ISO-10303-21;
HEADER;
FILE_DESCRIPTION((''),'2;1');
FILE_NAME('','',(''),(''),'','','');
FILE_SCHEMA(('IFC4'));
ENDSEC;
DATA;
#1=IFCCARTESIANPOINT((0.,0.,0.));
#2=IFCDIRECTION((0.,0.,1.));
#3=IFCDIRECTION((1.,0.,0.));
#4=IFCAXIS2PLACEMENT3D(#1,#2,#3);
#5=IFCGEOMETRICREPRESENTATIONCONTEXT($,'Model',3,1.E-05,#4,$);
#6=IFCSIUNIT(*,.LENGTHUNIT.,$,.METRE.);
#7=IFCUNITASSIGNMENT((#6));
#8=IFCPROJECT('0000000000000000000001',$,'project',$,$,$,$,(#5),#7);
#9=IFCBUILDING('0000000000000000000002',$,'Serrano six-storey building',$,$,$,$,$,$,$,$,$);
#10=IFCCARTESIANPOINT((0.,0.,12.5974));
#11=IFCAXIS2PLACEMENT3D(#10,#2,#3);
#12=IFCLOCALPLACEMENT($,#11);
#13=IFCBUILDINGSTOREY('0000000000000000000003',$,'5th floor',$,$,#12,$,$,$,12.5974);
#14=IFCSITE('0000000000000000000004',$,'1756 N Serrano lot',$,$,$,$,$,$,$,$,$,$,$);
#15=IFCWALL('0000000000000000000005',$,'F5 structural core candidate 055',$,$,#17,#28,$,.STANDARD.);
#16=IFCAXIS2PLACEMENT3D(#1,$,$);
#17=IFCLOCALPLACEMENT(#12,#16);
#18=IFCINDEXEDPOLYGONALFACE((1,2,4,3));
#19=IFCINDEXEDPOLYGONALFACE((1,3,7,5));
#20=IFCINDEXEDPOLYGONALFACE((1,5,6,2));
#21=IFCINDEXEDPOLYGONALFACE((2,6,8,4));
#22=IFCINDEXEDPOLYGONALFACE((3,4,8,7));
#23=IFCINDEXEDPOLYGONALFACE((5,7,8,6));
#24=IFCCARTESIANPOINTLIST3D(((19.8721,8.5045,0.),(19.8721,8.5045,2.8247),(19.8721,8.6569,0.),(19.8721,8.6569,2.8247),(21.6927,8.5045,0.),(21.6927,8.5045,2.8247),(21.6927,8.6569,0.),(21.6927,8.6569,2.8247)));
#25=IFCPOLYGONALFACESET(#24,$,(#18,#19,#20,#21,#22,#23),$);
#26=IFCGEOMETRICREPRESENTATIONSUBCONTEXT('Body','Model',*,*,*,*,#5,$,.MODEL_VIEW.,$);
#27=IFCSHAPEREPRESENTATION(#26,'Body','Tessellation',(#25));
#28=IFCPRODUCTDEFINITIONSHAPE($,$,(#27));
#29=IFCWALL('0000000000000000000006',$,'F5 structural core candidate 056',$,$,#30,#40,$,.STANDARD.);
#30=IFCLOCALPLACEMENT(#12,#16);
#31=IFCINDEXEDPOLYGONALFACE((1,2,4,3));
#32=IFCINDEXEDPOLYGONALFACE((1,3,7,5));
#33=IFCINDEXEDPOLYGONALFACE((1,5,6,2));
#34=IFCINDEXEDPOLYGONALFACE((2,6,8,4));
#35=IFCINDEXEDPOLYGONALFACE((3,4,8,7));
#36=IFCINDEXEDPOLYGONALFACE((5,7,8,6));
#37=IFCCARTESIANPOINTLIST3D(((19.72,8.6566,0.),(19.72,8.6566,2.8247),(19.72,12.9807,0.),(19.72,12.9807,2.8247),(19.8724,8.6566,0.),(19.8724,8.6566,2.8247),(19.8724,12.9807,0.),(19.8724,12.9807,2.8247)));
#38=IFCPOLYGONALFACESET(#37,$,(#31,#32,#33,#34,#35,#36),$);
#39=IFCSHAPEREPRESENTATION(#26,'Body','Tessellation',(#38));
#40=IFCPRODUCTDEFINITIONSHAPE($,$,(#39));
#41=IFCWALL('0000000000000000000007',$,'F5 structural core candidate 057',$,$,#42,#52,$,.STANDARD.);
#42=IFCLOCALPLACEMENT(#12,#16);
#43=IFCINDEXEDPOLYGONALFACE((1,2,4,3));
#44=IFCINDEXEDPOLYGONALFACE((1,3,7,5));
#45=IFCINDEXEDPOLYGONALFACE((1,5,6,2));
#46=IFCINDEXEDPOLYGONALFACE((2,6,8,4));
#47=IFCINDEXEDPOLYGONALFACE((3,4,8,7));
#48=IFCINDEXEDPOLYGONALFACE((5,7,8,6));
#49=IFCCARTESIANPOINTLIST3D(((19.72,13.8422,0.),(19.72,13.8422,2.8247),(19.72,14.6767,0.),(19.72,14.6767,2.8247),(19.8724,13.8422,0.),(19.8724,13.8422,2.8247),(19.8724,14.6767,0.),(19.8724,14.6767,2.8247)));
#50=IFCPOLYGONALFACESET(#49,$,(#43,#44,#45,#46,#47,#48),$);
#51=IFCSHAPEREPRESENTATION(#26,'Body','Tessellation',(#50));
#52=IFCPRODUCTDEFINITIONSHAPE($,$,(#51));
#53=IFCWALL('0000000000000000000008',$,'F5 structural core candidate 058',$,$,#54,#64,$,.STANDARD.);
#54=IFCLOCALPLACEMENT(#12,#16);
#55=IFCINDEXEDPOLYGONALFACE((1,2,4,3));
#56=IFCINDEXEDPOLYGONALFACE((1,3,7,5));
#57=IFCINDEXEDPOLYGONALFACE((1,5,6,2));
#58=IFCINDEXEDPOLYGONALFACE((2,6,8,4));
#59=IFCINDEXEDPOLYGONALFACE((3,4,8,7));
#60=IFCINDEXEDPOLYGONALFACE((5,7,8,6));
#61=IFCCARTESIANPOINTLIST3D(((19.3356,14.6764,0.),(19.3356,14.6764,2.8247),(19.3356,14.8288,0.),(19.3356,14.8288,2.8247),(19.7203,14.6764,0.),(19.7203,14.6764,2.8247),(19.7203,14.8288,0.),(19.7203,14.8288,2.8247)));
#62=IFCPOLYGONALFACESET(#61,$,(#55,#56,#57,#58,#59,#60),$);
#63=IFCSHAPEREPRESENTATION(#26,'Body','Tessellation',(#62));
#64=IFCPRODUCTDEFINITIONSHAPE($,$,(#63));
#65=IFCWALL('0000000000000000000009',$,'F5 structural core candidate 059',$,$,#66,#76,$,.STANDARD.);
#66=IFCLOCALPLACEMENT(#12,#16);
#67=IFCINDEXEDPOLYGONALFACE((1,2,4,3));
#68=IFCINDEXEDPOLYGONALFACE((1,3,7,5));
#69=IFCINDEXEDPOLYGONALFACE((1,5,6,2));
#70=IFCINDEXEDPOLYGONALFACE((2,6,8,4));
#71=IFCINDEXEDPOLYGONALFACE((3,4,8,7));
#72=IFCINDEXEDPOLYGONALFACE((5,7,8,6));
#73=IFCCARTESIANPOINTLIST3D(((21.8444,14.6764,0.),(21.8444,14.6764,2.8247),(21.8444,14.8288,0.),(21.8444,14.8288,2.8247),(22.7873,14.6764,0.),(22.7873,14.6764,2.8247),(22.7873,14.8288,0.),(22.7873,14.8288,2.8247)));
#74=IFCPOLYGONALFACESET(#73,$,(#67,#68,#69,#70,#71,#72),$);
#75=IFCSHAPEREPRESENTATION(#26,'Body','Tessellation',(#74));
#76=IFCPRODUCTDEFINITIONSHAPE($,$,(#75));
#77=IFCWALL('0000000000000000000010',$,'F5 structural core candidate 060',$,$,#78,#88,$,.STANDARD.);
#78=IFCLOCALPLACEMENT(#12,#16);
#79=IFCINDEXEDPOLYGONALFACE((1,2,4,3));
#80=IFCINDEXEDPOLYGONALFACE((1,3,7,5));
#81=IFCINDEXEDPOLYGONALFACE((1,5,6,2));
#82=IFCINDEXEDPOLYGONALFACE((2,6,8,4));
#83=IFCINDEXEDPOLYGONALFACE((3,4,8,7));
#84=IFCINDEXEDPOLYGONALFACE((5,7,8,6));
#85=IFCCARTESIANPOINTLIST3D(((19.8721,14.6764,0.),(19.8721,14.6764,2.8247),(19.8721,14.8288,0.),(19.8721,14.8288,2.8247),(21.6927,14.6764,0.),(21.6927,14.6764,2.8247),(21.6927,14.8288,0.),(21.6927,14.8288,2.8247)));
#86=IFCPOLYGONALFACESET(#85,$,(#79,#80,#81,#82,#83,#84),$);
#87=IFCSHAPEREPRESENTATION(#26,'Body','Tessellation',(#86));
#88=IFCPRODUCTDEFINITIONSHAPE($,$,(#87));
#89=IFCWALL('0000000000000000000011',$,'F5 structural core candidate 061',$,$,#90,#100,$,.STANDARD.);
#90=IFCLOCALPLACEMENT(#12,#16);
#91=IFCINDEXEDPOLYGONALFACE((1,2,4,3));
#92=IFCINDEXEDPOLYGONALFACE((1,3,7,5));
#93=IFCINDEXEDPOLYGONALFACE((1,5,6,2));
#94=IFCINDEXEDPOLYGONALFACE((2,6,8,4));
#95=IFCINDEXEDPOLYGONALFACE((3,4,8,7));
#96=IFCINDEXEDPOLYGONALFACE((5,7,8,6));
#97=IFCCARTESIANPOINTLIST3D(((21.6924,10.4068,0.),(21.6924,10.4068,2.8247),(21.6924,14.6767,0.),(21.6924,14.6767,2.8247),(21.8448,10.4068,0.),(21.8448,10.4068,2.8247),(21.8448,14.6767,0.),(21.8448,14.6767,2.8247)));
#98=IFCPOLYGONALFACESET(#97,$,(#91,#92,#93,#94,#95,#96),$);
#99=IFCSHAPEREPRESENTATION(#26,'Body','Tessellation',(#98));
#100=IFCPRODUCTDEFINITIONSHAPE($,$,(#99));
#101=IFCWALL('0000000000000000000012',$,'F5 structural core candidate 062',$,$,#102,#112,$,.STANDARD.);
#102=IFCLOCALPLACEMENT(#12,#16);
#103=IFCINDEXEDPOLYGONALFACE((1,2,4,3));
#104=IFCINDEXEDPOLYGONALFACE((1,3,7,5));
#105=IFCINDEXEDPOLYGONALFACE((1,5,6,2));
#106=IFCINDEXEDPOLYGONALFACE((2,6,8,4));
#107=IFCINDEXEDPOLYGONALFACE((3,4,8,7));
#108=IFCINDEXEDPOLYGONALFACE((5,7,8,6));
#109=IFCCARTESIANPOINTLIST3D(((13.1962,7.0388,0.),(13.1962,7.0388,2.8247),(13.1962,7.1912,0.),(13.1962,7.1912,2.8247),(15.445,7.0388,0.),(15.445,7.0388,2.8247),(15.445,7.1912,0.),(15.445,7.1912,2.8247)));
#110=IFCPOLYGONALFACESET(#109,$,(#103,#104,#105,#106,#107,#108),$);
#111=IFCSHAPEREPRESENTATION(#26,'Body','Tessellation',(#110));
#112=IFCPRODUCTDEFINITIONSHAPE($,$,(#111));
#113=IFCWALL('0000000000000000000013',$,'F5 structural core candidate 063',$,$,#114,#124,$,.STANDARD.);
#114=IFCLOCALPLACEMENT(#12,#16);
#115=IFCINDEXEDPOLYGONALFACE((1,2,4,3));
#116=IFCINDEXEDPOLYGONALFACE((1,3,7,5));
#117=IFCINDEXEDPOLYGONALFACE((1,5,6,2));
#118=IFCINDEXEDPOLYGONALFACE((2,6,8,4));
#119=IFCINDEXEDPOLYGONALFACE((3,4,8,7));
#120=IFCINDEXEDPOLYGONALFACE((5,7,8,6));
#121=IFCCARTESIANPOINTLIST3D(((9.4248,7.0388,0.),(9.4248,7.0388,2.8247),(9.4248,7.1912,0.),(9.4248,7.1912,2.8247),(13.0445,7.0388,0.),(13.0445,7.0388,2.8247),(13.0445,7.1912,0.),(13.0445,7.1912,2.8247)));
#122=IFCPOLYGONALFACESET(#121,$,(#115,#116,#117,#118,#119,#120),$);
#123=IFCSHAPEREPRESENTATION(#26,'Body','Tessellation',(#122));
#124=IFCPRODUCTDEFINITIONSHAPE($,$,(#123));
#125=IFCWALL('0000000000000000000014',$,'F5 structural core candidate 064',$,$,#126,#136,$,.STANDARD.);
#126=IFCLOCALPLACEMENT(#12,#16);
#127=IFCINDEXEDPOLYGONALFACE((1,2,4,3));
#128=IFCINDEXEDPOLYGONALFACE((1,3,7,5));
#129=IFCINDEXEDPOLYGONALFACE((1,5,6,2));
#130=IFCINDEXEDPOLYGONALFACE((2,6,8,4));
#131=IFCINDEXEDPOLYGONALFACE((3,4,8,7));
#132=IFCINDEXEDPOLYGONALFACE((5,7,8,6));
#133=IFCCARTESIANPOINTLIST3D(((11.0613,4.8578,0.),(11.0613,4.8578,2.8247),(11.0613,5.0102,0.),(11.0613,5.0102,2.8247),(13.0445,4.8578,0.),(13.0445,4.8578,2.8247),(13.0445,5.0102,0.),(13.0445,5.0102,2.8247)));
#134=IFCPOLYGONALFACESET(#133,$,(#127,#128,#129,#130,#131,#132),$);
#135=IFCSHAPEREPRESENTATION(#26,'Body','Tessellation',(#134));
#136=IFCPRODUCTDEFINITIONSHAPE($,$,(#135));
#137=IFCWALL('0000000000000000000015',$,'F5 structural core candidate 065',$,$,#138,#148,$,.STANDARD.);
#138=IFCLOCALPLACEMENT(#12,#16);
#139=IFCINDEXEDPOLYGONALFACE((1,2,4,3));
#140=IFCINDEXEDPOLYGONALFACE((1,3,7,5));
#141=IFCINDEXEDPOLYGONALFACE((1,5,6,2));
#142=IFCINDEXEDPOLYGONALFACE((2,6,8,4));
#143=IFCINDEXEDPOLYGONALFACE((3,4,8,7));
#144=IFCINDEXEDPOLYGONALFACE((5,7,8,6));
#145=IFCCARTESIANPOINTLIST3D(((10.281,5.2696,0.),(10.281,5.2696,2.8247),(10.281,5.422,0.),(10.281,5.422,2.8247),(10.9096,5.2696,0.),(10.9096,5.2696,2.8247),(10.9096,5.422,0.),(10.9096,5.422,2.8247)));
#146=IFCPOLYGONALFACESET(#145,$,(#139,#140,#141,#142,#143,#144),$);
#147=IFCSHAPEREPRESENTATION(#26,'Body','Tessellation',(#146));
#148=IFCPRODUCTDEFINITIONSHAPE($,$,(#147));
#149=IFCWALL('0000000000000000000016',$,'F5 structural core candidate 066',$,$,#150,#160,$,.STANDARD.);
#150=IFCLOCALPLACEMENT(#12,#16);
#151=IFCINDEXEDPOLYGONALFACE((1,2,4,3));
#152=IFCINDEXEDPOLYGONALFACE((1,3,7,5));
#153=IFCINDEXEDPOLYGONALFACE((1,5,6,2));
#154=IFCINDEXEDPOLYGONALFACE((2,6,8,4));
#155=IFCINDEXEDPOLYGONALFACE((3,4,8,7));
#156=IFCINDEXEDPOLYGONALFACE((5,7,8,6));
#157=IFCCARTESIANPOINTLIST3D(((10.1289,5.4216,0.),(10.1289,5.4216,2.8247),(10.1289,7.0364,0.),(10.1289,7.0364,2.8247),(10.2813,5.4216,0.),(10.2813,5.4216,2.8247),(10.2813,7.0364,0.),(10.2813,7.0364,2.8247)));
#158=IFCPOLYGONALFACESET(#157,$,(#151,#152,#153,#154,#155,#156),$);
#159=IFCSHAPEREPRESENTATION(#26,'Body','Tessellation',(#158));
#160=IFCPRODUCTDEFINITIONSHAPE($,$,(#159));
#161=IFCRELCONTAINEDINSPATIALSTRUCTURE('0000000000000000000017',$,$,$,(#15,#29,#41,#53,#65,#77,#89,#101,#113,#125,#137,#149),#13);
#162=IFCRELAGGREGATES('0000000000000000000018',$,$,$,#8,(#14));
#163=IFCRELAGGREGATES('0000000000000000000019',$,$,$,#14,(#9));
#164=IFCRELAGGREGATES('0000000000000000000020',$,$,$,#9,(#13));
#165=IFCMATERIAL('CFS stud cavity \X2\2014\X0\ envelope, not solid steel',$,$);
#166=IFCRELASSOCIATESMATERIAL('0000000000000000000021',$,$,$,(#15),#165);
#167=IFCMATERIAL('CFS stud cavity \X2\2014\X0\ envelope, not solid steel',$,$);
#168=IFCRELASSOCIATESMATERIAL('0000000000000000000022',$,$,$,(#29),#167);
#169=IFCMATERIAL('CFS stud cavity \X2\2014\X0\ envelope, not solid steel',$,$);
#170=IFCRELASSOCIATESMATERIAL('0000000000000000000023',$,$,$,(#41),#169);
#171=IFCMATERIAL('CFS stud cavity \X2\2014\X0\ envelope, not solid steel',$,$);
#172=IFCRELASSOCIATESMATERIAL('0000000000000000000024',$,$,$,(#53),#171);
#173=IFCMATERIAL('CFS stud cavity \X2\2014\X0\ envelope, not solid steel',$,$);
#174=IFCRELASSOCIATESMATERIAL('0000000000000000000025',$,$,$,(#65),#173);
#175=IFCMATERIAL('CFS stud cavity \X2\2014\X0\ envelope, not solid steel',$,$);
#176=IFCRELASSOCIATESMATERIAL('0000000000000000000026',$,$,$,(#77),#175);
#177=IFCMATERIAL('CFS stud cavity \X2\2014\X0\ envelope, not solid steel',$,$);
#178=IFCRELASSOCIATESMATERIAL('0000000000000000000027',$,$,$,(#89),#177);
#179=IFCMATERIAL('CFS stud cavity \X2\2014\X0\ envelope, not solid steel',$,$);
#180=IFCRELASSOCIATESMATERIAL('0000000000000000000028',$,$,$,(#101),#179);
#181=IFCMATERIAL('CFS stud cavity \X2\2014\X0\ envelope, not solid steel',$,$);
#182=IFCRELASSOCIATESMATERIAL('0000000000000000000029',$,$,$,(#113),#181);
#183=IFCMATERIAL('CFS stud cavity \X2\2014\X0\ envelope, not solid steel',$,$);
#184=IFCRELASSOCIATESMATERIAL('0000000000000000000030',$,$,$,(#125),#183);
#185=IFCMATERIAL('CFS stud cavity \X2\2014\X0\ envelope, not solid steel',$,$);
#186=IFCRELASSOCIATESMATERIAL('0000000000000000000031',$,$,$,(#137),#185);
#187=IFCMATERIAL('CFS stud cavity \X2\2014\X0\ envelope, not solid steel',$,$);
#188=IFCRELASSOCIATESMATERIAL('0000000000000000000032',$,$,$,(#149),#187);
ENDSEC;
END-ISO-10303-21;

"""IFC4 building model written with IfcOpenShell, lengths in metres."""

from ifc_helpers import new_model, si_unit, frame, origin_with_axes, place, context, subcontext, project, spatial, polyline, outline, extrude, material, element, save


model = new_model("IFC4")

# Units and contexts
model_context = context("Model", 3, precision=1e-05, world=origin_with_axes())
body_context = subcontext(model_context, "Body", "Model", "MODEL_VIEW")
ifc_project = project(units=[si_unit("LENGTHUNIT", "METRE")], contexts=[model_context])

# Site, building, storey
site = spatial("IfcSite", under=ifc_project, Name="1756 N Serrano lot")
building = spatial("IfcBuilding", under=site, Name="Serrano six-storey building")
storey_placement = place(None, frame((0.0, 0.0, 12.5974), z_axis=(0.0, 0.0, 1.0), x_axis=(1.0, 0.0, 0.0)))
storey = spatial("IfcBuildingStorey", under=building, at=storey_placement, Name="5th floor", Elevation=12.5974)

# Walls
ifc_material_1 = material(Name="CFS stud cavity — envelope, not solid steel")
wall_1_placement = place(storey_placement, frame((0.0, 0.0, -12.5974), z_axis=(0.0, 0.0, 1.0), x_axis=(1.0, 0.0, 0.0)))
element("IfcWall", 1, at=wall_1_placement, inside=storey, material=ifc_material_1, Name="F5 structural core candidate 055", PredefinedType="STANDARD", context=body_context, shape_type="SweptSolid", body=[
    extrude(outline(polyline([(21.6927, 8.6569), (21.6927, 8.5045), (19.8721, 8.5045), (19.8721, 8.6569), (21.6927, 8.6569)])), frame((0.0, 0.0, 12.5974)), (0.0, 0.0, 1.0), 2.8247),
])
ifc_material_2 = material(Name="CFS stud cavity — envelope, not solid steel")
wall_2_placement = place(storey_placement, frame((0.0, 0.0, -12.5974), z_axis=(0.0, 0.0, 1.0), x_axis=(1.0, 0.0, 0.0)))
element("IfcWall", 2, at=wall_2_placement, inside=storey, material=ifc_material_2, Name="F5 structural core candidate 056", PredefinedType="STANDARD", context=body_context, shape_type="SweptSolid", body=[
    extrude(outline(polyline([(19.8724, 8.6566), (19.72, 8.6566), (19.72, 12.9807), (19.8724, 12.9807), (19.8724, 8.6566)])), frame((0.0, 0.0, 12.5974)), (0.0, 0.0, 1.0), 2.8247),
])
ifc_material_3 = material(Name="CFS stud cavity — envelope, not solid steel")
wall_3_placement = place(storey_placement, frame((0.0, 0.0, -12.5974), z_axis=(0.0, 0.0, 1.0), x_axis=(1.0, 0.0, 0.0)))
element("IfcWall", 3, at=wall_3_placement, inside=storey, material=ifc_material_3, Name="F5 structural core candidate 057", PredefinedType="STANDARD", context=body_context, shape_type="SweptSolid", body=[
    extrude(outline(polyline([(19.8724, 13.8422), (19.72, 13.8422), (19.72, 14.6767), (19.8724, 14.6767), (19.8724, 13.8422)])), frame((0.0, 0.0, 12.5974)), (0.0, 0.0, 1.0), 2.8247),
])
ifc_material_4 = material(Name="CFS stud cavity — envelope, not solid steel")
wall_4_placement = place(storey_placement, frame((0.0, 0.0, -12.5974), z_axis=(0.0, 0.0, 1.0), x_axis=(1.0, 0.0, 0.0)))
element("IfcWall", 4, at=wall_4_placement, inside=storey, material=ifc_material_4, Name="F5 structural core candidate 058", PredefinedType="STANDARD", context=body_context, shape_type="SweptSolid", body=[
    extrude(outline(polyline([(19.7203, 14.8288), (19.7203, 14.6764), (19.3356, 14.6764), (19.3356, 14.8288), (19.7203, 14.8288)])), frame((0.0, 0.0, 12.5974)), (0.0, 0.0, 1.0), 2.8247),
])
ifc_material_5 = material(Name="CFS stud cavity — envelope, not solid steel")
wall_5_placement = place(storey_placement, frame((0.0, 0.0, -12.5974), z_axis=(0.0, 0.0, 1.0), x_axis=(1.0, 0.0, 0.0)))
element("IfcWall", 5, at=wall_5_placement, inside=storey, material=ifc_material_5, Name="F5 structural core candidate 059", PredefinedType="STANDARD", context=body_context, shape_type="SweptSolid", body=[
    extrude(outline(polyline([(22.7873, 14.8288), (22.7873, 14.6764), (21.8444, 14.6764), (21.8444, 14.8288), (22.7873, 14.8288)])), frame((0.0, 0.0, 12.5974)), (0.0, 0.0, 1.0), 2.8247),
])
ifc_material_6 = material(Name="CFS stud cavity — envelope, not solid steel")
wall_6_placement = place(storey_placement, frame((0.0, 0.0, -12.5974), z_axis=(0.0, 0.0, 1.0), x_axis=(1.0, 0.0, 0.0)))
element("IfcWall", 6, at=wall_6_placement, inside=storey, material=ifc_material_6, Name="F5 structural core candidate 060", PredefinedType="STANDARD", context=body_context, shape_type="SweptSolid", body=[
    extrude(outline(polyline([(21.6927, 14.8288), (21.6927, 14.6764), (19.8721, 14.6764), (19.8721, 14.8288), (21.6927, 14.8288)])), frame((0.0, 0.0, 12.5974)), (0.0, 0.0, 1.0), 2.8247),
])
ifc_material_7 = material(Name="CFS stud cavity — envelope, not solid steel")
wall_7_placement = place(storey_placement, frame((0.0, 0.0, -12.5974), z_axis=(0.0, 0.0, 1.0), x_axis=(1.0, 0.0, 0.0)))
element("IfcWall", 7, at=wall_7_placement, inside=storey, material=ifc_material_7, Name="F5 structural core candidate 061", PredefinedType="STANDARD", context=body_context, shape_type="SweptSolid", body=[
    extrude(outline(polyline([(21.8448, 10.4068), (21.6924, 10.4068), (21.6924, 14.6767), (21.8448, 14.6767), (21.8448, 10.4068)])), frame((0.0, 0.0, 12.5974)), (0.0, 0.0, 1.0), 2.8247),
])
ifc_material_8 = material(Name="CFS stud cavity — envelope, not solid steel")
wall_8_placement = place(storey_placement, frame((0.0, 0.0, -12.5974), z_axis=(0.0, 0.0, 1.0), x_axis=(1.0, 0.0, 0.0)))
element("IfcWall", 8, at=wall_8_placement, inside=storey, material=ifc_material_8, Name="F5 structural core candidate 062", PredefinedType="STANDARD", context=body_context, shape_type="SweptSolid", body=[
    extrude(outline(polyline([(15.445, 7.1912), (15.445, 7.0388), (13.1962, 7.0388), (13.1962, 7.1912), (15.445, 7.1912)])), frame((0.0, 0.0, 12.5974)), (0.0, 0.0, 1.0), 2.8247),
])
ifc_material_9 = material(Name="CFS stud cavity — envelope, not solid steel")
wall_9_placement = place(storey_placement, frame((0.0, 0.0, -12.5974), z_axis=(0.0, 0.0, 1.0), x_axis=(1.0, 0.0, 0.0)))
element("IfcWall", 9, at=wall_9_placement, inside=storey, material=ifc_material_9, Name="F5 structural core candidate 063", PredefinedType="STANDARD", context=body_context, shape_type="SweptSolid", body=[
    extrude(outline(polyline([(13.0445, 7.1912), (13.0445, 7.0388), (9.4248, 7.0388), (9.4248, 7.1912), (13.0445, 7.1912)])), frame((0.0, 0.0, 12.5974)), (0.0, 0.0, 1.0), 2.8247),
])
ifc_material_10 = material(Name="CFS stud cavity — envelope, not solid steel")
wall_10_placement = place(storey_placement, frame((0.0, 0.0, -12.5974), z_axis=(0.0, 0.0, 1.0), x_axis=(1.0, 0.0, 0.0)))
element("IfcWall", 10, at=wall_10_placement, inside=storey, material=ifc_material_10, Name="F5 structural core candidate 064", PredefinedType="STANDARD", context=body_context, shape_type="SweptSolid", body=[
    extrude(outline(polyline([(13.0445, 5.0102), (13.0445, 4.8578), (11.0613, 4.8578), (11.0613, 5.0102), (13.0445, 5.0102)])), frame((0.0, 0.0, 12.5974)), (0.0, 0.0, 1.0), 2.8247),
])
ifc_material_11 = material(Name="CFS stud cavity — envelope, not solid steel")
wall_11_placement = place(storey_placement, frame((0.0, 0.0, -12.5974), z_axis=(0.0, 0.0, 1.0), x_axis=(1.0, 0.0, 0.0)))
element("IfcWall", 11, at=wall_11_placement, inside=storey, material=ifc_material_11, Name="F5 structural core candidate 065", PredefinedType="STANDARD", context=body_context, shape_type="SweptSolid", body=[
    extrude(outline(polyline([(10.9096, 5.422), (10.9096, 5.2696), (10.281, 5.2696), (10.281, 5.422), (10.9096, 5.422)])), frame((0.0, 0.0, 12.5974)), (0.0, 0.0, 1.0), 2.8247),
])
ifc_material_12 = material(Name="CFS stud cavity — envelope, not solid steel")
wall_12_placement = place(storey_placement, frame((0.0, 0.0, -12.5974), z_axis=(0.0, 0.0, 1.0), x_axis=(1.0, 0.0, 0.0)))
element("IfcWall", 12, at=wall_12_placement, inside=storey, material=ifc_material_12, Name="F5 structural core candidate 066", PredefinedType="STANDARD", context=body_context, shape_type="SweptSolid", body=[
    extrude(outline(polyline([(10.2813, 5.4216), (10.1289, 5.4216), (10.1289, 7.0364), (10.2813, 7.0364), (10.2813, 5.4216)])), frame((0.0, 0.0, 12.5974)), (0.0, 0.0, 1.0), 2.8247),
])

save(model, "model.ifc")
